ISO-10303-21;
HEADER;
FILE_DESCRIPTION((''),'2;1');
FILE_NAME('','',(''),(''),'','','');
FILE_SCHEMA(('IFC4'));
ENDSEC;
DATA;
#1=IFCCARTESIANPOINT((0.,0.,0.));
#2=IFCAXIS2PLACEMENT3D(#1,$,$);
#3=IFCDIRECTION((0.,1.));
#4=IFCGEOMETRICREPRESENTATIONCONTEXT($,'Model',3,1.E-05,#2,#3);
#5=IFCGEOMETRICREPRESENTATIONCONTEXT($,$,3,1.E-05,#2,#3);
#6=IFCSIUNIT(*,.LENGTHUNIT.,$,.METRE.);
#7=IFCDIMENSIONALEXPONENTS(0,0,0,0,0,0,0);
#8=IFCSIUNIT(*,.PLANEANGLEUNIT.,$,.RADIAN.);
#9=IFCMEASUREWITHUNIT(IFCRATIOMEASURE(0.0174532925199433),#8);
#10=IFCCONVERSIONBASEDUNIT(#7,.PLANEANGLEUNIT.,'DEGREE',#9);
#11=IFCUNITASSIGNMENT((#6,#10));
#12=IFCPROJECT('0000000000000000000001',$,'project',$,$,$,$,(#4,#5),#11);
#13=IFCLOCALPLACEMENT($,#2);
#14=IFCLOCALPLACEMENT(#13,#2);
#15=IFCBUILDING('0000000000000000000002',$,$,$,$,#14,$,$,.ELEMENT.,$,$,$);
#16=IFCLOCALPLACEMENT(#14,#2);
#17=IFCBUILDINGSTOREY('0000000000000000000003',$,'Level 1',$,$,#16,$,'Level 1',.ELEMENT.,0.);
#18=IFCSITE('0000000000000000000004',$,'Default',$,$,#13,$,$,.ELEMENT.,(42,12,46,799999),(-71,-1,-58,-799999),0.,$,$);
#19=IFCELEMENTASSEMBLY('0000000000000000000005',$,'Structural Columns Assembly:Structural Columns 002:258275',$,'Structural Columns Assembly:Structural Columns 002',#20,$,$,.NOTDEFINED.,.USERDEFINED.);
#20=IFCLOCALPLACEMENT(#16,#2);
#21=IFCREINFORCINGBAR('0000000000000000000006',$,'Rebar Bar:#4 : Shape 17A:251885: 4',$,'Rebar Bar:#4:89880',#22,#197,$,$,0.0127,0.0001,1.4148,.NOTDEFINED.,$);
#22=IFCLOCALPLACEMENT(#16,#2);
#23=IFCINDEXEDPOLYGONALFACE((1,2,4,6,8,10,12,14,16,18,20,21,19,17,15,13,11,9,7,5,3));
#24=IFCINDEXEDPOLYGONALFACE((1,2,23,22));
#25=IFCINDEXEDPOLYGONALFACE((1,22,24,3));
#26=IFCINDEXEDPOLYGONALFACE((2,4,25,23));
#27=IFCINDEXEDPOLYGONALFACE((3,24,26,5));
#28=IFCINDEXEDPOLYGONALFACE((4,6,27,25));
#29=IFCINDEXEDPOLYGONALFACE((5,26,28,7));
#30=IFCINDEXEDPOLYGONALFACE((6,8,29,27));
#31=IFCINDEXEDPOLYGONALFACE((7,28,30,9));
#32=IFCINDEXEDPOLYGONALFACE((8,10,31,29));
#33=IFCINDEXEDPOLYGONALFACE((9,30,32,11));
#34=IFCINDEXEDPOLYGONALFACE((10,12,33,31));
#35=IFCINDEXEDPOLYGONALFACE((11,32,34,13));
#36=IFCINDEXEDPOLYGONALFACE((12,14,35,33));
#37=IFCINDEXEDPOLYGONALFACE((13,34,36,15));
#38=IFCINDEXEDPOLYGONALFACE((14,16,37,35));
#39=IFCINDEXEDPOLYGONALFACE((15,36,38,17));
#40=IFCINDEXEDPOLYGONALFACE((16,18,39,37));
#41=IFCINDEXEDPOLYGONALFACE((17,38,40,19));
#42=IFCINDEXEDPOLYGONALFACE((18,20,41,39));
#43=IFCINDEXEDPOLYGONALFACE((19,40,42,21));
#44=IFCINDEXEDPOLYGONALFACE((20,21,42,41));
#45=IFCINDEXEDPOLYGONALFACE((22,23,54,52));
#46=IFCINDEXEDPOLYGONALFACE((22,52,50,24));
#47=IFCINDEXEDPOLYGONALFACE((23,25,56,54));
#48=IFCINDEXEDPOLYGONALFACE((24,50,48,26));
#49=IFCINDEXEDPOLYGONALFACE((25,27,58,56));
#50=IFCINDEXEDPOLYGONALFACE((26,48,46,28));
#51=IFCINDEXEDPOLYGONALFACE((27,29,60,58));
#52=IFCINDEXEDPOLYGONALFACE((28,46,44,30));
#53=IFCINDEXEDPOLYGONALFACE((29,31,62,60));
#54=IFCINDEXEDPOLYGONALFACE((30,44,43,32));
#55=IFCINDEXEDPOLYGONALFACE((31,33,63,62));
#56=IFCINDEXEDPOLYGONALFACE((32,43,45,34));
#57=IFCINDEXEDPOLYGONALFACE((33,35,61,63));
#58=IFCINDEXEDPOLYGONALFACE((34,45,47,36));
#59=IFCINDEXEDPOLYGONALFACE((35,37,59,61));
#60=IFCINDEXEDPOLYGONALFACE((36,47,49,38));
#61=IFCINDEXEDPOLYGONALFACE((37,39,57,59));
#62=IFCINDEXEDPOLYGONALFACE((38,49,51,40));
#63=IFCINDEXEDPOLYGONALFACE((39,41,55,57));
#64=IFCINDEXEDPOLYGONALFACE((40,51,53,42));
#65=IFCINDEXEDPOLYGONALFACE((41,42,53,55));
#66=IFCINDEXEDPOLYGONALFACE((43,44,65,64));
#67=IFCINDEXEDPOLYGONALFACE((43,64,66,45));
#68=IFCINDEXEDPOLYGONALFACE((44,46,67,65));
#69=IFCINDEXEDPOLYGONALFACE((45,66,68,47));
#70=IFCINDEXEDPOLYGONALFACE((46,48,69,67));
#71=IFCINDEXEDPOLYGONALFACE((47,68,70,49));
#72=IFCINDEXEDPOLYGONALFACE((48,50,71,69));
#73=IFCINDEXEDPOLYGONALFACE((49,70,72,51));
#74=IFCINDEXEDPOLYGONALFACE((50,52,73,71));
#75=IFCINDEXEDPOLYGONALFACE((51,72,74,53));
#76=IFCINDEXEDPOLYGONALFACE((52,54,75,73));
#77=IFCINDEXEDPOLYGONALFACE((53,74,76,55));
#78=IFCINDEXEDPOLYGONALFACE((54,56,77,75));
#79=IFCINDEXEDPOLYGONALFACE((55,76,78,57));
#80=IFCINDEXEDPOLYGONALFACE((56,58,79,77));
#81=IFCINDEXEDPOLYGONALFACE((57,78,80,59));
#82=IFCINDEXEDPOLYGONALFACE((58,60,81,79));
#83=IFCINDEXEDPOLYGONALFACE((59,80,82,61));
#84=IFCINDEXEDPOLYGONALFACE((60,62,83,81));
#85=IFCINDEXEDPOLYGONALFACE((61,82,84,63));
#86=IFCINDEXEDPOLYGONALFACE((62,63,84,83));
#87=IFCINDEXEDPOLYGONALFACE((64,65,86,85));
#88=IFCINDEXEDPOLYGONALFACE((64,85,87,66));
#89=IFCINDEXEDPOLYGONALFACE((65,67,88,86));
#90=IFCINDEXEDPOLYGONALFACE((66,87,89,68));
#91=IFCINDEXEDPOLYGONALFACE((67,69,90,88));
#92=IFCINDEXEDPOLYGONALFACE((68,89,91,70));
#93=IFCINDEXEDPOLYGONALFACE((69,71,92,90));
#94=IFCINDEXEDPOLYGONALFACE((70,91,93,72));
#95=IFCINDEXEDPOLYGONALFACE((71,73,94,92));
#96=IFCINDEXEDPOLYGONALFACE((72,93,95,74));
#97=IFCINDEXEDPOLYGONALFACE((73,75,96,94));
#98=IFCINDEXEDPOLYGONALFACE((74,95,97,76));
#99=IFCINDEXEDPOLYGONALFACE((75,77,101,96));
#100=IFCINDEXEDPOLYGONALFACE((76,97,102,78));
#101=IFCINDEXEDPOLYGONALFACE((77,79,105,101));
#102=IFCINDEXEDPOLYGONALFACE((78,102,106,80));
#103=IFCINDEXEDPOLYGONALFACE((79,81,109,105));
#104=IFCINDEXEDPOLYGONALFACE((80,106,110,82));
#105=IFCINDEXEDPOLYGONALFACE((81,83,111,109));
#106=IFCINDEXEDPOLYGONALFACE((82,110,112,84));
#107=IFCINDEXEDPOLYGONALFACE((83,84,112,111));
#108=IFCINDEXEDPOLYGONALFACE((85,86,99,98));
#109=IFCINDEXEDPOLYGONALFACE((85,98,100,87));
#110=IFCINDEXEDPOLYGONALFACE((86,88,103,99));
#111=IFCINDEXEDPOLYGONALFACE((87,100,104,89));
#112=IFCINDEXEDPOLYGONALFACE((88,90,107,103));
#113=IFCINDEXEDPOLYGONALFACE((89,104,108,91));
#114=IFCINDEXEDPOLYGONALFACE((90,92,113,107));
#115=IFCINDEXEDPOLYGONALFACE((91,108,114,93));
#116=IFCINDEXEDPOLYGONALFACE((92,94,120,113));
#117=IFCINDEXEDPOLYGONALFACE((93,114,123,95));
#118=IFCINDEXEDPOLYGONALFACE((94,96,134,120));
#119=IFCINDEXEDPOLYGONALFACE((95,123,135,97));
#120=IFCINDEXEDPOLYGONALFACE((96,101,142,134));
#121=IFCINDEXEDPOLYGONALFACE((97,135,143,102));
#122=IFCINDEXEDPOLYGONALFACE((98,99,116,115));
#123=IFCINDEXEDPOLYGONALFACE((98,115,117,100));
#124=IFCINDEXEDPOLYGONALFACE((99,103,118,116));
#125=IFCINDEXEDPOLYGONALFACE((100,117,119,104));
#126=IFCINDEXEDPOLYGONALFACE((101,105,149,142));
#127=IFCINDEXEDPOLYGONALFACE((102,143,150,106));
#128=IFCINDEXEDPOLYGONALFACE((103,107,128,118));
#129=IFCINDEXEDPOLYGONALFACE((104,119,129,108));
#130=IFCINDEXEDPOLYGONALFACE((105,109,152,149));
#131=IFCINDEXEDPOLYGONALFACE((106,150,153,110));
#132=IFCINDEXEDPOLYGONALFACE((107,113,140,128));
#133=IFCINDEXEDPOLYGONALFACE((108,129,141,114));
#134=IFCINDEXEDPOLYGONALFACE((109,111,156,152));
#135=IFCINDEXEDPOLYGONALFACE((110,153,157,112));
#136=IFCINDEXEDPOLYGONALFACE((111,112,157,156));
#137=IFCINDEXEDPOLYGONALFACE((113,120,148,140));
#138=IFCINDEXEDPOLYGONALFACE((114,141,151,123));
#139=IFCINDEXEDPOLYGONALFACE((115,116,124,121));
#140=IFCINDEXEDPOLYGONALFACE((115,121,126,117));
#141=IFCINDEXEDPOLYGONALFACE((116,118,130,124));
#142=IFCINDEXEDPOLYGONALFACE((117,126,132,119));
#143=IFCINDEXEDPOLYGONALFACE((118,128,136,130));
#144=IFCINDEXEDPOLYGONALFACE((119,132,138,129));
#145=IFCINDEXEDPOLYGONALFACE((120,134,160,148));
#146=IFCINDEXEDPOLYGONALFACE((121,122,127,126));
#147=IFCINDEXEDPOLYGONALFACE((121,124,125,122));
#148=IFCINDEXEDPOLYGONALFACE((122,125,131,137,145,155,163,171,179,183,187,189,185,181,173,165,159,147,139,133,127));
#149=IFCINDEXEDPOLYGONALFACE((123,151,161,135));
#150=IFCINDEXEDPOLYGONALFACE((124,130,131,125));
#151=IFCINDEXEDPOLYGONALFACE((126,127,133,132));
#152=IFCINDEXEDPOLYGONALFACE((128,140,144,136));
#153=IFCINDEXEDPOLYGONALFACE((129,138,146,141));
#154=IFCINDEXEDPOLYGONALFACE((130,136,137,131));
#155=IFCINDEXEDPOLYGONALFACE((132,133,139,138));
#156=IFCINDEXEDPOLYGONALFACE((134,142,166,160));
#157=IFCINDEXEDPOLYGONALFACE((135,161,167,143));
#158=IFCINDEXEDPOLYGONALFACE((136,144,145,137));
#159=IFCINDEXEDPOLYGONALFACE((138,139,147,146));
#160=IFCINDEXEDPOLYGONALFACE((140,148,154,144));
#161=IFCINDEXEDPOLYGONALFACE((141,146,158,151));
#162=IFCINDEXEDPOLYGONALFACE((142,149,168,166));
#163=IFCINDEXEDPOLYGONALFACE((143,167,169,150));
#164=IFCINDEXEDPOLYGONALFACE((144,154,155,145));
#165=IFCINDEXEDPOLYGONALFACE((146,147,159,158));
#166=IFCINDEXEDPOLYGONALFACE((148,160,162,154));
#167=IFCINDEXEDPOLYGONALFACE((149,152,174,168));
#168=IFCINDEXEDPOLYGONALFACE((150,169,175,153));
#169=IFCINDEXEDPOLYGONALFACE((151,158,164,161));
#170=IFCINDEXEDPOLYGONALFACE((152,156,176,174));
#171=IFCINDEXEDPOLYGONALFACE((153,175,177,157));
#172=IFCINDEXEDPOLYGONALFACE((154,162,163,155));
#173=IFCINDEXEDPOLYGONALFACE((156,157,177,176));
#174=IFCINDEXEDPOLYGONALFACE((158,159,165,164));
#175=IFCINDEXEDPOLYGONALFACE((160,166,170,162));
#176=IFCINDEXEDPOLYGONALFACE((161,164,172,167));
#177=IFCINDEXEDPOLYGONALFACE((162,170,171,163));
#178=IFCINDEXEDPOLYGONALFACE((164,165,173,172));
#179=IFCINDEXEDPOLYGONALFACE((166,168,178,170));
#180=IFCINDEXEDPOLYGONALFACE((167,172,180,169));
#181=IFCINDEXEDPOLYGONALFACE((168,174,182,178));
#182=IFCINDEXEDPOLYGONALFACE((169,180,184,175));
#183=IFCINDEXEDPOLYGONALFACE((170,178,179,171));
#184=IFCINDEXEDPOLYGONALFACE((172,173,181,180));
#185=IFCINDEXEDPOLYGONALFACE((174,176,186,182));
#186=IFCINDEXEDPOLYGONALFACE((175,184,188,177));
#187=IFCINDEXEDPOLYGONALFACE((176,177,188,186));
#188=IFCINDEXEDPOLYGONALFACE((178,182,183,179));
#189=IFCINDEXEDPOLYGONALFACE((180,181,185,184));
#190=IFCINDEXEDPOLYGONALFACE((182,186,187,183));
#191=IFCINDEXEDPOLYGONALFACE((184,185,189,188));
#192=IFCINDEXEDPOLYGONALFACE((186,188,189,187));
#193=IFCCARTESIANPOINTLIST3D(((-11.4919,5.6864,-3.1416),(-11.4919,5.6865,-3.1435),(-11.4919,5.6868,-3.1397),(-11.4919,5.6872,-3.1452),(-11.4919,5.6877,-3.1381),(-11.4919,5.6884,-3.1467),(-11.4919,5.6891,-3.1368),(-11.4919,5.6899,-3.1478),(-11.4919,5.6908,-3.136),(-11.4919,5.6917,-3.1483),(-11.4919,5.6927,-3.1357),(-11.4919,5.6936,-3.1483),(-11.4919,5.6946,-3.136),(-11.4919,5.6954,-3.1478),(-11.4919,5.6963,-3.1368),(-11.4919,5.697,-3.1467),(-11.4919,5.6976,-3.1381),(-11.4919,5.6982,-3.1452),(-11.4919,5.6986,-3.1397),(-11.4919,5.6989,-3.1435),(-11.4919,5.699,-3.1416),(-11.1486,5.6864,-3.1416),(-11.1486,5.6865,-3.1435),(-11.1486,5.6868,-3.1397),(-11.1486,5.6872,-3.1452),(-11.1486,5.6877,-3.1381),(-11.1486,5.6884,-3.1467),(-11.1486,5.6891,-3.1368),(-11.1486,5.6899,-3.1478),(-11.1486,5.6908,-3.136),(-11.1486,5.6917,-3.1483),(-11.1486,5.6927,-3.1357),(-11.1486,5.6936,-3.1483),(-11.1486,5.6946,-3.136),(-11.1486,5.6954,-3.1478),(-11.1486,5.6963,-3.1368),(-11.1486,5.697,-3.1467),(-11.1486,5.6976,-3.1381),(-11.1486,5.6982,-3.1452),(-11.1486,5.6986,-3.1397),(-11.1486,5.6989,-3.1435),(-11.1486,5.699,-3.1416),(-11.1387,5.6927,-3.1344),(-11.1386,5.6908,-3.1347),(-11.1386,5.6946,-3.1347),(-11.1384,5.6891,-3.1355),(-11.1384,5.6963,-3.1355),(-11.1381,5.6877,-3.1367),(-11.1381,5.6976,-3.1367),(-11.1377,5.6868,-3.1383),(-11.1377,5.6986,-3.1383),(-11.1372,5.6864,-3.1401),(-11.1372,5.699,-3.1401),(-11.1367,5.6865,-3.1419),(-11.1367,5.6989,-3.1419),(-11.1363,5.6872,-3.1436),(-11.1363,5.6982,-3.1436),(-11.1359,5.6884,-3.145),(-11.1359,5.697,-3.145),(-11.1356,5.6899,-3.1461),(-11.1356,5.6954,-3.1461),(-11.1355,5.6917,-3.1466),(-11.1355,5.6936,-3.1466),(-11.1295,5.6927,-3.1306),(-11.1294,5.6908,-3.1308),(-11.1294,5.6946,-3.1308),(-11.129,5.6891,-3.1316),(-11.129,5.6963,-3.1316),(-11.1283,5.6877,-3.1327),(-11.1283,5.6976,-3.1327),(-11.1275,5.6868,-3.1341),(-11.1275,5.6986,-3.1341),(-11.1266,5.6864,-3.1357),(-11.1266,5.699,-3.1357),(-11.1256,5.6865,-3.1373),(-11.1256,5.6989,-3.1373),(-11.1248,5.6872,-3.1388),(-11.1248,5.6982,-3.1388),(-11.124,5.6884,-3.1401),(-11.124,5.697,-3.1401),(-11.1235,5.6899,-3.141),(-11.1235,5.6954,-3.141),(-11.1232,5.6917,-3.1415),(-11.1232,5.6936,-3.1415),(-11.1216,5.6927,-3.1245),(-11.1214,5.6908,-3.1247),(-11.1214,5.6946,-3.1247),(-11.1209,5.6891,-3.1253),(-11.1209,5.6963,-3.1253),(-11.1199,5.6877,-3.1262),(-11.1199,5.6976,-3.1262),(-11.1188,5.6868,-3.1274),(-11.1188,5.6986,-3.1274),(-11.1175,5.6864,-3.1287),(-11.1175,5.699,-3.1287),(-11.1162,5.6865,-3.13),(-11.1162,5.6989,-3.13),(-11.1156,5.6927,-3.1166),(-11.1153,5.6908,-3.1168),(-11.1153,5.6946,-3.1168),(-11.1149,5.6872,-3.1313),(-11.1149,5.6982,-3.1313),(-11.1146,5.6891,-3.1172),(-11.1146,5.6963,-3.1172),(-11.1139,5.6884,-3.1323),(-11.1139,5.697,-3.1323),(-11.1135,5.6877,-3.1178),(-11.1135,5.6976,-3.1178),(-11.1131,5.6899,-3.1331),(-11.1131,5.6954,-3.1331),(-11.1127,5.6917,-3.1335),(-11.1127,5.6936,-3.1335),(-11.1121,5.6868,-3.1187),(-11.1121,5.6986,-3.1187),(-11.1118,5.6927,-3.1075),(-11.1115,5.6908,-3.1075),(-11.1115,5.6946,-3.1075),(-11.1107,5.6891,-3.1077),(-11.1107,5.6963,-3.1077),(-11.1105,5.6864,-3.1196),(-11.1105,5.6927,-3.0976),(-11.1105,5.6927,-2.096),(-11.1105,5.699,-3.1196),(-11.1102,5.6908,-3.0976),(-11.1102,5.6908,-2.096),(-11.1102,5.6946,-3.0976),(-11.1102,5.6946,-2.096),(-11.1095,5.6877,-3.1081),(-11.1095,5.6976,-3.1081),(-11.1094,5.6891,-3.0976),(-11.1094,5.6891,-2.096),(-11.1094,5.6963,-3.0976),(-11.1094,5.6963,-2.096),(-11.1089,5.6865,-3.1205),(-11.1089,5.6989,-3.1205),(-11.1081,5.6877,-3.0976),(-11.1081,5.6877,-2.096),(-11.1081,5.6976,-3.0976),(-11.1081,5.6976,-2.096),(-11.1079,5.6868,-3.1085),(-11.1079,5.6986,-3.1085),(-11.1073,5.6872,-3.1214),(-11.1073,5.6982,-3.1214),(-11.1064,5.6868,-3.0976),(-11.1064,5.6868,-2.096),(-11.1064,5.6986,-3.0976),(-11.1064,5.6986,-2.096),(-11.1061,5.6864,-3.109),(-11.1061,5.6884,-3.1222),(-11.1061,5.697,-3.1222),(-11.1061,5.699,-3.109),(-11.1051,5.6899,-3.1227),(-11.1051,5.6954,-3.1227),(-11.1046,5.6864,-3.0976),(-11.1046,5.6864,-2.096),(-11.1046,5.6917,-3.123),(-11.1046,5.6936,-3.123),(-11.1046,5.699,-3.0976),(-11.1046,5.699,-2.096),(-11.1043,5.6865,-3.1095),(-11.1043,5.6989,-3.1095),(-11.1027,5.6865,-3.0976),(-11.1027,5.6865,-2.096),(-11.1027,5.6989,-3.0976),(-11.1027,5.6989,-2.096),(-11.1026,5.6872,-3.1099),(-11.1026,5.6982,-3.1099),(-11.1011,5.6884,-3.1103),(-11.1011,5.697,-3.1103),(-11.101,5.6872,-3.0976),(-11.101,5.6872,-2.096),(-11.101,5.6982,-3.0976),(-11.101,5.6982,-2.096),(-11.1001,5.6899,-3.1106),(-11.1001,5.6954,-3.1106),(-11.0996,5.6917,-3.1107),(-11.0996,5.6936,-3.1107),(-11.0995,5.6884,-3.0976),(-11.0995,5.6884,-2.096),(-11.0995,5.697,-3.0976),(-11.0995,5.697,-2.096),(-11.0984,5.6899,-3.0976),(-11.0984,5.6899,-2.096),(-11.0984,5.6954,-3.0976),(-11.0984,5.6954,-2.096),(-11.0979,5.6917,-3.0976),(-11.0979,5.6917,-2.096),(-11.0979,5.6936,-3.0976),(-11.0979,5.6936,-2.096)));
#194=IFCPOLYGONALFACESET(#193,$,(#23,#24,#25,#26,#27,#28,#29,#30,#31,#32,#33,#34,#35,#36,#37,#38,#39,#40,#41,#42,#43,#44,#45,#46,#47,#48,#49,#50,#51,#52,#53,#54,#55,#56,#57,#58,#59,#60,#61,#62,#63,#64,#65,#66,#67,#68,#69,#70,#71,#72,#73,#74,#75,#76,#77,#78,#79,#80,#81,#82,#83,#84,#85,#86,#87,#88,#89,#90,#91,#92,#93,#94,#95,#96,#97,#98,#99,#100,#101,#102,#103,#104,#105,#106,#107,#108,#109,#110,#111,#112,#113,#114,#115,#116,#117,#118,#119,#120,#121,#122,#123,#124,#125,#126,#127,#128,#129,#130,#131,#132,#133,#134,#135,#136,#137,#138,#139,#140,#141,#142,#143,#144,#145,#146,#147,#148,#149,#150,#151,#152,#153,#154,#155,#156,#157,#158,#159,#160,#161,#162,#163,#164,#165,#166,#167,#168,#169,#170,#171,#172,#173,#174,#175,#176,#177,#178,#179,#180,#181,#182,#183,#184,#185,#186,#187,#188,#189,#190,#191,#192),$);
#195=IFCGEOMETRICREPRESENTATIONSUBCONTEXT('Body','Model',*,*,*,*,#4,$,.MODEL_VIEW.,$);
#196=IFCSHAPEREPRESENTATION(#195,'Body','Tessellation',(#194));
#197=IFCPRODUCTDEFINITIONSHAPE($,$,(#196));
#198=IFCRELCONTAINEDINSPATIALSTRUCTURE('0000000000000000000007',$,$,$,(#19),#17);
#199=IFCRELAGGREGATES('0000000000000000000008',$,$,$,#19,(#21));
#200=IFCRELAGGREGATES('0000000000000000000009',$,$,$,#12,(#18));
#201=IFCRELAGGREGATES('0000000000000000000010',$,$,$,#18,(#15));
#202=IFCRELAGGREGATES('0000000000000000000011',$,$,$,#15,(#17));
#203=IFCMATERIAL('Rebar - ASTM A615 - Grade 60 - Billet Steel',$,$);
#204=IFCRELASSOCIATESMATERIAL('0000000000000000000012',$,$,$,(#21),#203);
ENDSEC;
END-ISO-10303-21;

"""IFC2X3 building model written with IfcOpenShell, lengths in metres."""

from ifc_helpers import new_model, entity, si_unit, converted_unit, direction, origin, place, context, subcontext, project, spatial, material, element, aggregate, save


model = new_model("IFC2X3")

# Units and contexts
model_context = context("Model", 3, precision=1e-05, world=origin(), true_north=direction((0.0, 1.0)))
context_of_model = context(None, 3, precision=1e-05, world=origin(), true_north=direction((0.0, 1.0)))
body_context = subcontext(model_context, "Body", "Model", "MODEL_VIEW")
ifc_project = project(units=[si_unit("LENGTHUNIT", "METRE"), converted_unit("PLANEANGLEUNIT", "DEGREE", entity("IfcRatioMeasure", 0.0174532925199433), si_unit("PLANEANGLEUNIT", "RADIAN"), dimensions=[0, 0, 0, 0, 0, 0, 0])], contexts=[model_context, context_of_model])

# Site, building, storey
site_placement = place(None, origin())
site = spatial("IfcSite", under=ifc_project, at=site_placement, Name="Default", CompositionType="ELEMENT", RefLatitude=(42, 12, 46, 799999), RefLongitude=(-71, -1, -58, -799999), RefElevation=0.0)
building_placement = place(site_placement, origin())
building = spatial("IfcBuilding", under=site, at=building_placement, CompositionType="ELEMENT")
storey_placement = place(building_placement, origin())
storey = spatial("IfcBuildingStorey", under=building, at=storey_placement, Name="Level 1", LongName="Level 1", CompositionType="ELEMENT", Elevation=0.0)

# Element assembly, reinforcing bar
assembly_1_placement = place(storey_placement, origin())
assembly_1 = element("IfcElementAssembly", 1, at=assembly_1_placement, inside=storey, Name="Structural Columns Assembly:Structural Columns 002:258275", ObjectType="Structural Columns Assembly:Structural Columns 002", AssemblyPlace="NOTDEFINED", PredefinedType="USERDEFINED")
ifc_material_1 = material(Name="Rebar - ASTM A615 - Grade 60 - Billet Steel")
reinforcing_bar_1_placement = place(assembly_1_placement, origin())
reinforcing_bar_1 = element("IfcReinforcingBar", 2, at=reinforcing_bar_1_placement, material=ifc_material_1, Name="Rebar Bar:#4 : Shape 17A:251885: 4", ObjectType="Rebar Bar:#4:89880", BarLength=1.4148, BarRole="NOTDEFINED", CrossSectionArea=0.0001, NominalDiameter=0.0127, context=body_context, shape_type="AdvancedSweptSolid", body=[
    entity("IfcSweptDiskSolid", entity("IfcCompositeCurve", [entity("IfcCompositeCurveSegment", "CONTINUOUS", True, entity("IfcPolyline", [entity("IfcCartesianPoint", [-11.4919, 5.6927, -3.142]), entity("IfcCartesianPoint", [-11.1486, 5.6927, -3.142])])), entity("IfcCompositeCurveSegment", "CONTINUOUS", True, entity("IfcTrimmedCurve", entity("IfcCircle", entity("IfcAxis2Placement3D", entity("IfcCartesianPoint", [-11.1486, 5.6927, -3.0976]), entity("IfcDirection", [0.0, -1.0, 0.0]), entity("IfcDirection", [1.0, 0.0, 0.0])), 0.0445), [entity("IfcParameterValue", 270.0)], [entity("IfcParameterValue", 360.0)], True, "PARAMETER")), entity("IfcCompositeCurveSegment", "CONTINUOUS", True, entity("IfcPolyline", [entity("IfcCartesianPoint", [-11.1041, 5.6927, -3.0976]), entity("IfcCartesianPoint", [-11.1041, 5.6927, -2.096])]))], False), 0.0063, None, 0.0, 92.0),
])
aggregate(assembly_1, [reinforcing_bar_1])

save(model, "model.ifc")
